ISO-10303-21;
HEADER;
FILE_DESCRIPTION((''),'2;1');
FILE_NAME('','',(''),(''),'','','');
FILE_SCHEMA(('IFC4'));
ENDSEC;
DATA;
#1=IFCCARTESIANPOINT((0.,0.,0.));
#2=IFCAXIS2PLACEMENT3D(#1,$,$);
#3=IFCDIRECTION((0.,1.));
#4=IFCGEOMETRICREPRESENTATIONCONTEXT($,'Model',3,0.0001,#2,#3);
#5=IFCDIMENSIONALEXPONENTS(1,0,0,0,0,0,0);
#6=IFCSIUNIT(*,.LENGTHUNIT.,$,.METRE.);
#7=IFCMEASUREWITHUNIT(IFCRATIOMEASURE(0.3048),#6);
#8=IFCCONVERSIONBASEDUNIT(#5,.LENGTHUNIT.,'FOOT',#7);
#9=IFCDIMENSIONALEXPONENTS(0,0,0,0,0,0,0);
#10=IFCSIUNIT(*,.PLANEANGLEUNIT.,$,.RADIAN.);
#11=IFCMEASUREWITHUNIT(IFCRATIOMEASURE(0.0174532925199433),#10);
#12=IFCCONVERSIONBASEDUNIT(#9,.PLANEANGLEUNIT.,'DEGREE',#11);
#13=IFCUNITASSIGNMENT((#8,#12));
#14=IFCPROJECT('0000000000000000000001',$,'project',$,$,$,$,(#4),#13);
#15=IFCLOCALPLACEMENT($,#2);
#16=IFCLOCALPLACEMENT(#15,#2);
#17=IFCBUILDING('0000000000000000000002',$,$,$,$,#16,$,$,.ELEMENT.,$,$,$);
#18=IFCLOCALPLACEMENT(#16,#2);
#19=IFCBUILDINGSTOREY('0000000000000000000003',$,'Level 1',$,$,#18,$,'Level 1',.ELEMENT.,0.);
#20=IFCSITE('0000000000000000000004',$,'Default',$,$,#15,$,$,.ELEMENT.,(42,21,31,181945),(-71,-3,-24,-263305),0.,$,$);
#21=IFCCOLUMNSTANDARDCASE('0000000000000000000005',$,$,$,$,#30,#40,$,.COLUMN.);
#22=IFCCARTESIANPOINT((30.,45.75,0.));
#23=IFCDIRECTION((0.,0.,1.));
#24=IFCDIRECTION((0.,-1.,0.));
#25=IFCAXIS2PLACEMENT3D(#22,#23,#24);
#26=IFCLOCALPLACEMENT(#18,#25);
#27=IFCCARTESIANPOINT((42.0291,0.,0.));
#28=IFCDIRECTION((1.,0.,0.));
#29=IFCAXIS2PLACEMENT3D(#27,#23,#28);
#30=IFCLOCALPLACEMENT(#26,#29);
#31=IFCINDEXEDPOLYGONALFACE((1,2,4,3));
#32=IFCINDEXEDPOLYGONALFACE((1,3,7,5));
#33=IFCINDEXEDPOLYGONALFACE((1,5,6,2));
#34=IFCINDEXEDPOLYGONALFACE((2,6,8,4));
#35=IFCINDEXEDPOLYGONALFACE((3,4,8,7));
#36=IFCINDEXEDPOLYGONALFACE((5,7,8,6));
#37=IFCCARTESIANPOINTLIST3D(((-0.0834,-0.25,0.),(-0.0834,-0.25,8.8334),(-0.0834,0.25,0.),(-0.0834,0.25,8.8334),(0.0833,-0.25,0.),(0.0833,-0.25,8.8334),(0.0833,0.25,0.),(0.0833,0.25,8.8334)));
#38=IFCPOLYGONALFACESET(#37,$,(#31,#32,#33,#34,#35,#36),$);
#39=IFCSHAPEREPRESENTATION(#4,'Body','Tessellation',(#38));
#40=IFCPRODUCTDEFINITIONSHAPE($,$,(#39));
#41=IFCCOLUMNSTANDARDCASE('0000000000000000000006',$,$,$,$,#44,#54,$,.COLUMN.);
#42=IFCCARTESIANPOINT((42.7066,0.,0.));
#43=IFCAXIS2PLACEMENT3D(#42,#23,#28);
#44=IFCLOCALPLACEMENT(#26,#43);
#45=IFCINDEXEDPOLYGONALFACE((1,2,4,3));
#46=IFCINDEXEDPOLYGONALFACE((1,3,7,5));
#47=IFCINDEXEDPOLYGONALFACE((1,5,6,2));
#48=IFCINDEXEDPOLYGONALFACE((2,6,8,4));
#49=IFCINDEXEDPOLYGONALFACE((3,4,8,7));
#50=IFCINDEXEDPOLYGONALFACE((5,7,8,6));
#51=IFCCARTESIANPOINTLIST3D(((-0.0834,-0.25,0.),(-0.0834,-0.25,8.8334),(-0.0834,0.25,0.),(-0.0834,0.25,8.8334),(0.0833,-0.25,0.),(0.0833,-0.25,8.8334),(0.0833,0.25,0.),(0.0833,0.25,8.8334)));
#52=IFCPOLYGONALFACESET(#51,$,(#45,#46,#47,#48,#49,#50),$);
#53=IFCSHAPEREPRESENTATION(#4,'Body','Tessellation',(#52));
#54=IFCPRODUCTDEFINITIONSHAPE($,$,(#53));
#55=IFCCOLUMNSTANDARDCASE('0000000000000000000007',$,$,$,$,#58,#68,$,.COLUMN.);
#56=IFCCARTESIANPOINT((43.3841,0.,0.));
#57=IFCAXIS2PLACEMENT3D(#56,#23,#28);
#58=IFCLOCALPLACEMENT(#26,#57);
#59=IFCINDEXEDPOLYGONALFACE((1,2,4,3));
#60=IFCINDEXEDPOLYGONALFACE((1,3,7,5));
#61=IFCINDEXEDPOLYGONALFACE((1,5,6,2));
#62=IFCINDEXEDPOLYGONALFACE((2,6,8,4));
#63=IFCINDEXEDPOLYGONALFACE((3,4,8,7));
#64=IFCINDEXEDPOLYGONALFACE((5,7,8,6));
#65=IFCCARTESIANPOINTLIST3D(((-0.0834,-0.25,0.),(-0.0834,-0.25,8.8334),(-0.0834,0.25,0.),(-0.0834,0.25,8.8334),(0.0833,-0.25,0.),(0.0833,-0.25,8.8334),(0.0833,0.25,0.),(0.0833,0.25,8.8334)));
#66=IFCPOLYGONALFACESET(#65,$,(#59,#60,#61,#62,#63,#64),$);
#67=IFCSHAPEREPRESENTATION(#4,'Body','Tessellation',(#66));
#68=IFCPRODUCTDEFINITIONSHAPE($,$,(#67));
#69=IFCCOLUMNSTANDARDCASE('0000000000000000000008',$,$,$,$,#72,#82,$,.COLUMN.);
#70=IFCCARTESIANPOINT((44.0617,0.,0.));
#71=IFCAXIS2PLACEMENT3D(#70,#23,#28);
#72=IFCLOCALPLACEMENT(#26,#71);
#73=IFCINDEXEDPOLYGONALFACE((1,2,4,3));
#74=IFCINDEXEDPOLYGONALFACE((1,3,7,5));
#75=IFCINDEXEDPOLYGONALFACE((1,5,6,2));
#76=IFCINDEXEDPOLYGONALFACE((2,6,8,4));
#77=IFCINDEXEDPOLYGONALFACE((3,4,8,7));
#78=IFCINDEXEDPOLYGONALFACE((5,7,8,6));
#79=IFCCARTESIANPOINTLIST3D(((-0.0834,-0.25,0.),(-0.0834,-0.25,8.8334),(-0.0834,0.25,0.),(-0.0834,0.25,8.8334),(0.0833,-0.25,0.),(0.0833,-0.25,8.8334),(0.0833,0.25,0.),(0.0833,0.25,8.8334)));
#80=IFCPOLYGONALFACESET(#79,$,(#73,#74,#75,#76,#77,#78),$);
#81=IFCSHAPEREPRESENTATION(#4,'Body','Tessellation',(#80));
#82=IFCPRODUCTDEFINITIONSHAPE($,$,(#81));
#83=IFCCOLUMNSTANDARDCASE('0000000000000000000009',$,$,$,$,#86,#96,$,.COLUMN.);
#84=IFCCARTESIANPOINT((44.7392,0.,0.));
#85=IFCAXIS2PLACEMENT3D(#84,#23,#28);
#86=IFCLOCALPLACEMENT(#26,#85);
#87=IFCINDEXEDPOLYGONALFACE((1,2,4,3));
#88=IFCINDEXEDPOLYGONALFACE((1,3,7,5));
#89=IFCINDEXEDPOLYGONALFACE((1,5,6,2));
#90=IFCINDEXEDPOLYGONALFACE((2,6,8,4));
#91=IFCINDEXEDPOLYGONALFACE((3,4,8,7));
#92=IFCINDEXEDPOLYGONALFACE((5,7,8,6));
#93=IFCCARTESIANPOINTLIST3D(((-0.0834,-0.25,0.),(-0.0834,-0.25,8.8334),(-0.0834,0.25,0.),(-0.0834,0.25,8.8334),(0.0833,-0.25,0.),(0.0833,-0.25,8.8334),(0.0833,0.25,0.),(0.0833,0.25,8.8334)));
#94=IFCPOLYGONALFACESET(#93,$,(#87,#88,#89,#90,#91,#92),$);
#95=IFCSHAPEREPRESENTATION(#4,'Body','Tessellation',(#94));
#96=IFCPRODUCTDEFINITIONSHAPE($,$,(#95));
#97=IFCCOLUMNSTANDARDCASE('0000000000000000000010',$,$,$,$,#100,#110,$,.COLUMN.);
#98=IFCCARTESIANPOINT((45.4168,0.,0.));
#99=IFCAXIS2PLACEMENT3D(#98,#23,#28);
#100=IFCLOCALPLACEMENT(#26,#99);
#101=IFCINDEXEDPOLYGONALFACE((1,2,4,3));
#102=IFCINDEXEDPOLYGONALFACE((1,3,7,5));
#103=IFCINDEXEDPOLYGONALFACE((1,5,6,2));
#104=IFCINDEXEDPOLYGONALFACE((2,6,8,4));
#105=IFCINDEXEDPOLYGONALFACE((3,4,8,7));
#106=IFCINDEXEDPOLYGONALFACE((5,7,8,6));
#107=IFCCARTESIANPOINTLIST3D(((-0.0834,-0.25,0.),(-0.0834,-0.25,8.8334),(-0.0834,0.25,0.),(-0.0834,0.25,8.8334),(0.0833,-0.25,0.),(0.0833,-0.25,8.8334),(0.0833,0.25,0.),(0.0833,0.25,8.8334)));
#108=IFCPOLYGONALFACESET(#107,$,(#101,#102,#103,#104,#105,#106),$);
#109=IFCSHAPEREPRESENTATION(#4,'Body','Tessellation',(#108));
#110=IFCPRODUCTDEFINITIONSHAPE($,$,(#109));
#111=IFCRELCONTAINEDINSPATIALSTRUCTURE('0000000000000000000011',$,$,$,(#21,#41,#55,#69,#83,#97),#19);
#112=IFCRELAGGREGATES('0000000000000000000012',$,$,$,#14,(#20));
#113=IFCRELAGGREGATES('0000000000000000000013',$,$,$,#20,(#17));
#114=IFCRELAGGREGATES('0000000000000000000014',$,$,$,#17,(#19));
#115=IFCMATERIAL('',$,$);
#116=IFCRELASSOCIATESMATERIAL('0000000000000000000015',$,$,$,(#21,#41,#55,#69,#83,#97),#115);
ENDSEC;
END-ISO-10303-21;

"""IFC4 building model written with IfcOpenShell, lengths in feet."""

from ifc_helpers import new_model, entity, si_unit, converted_unit, direction, frame, origin, place, context, project, spatial, rectangle, extrude, material, element, save


model = new_model("IFC4")

# Units and contexts
model_context = context("Model", 3, precision=0.0001, world=origin(), true_north=direction((0.0, 1.0)))
ifc_project = project(units=[converted_unit("LENGTHUNIT", "FOOT", entity("IfcRatioMeasure", 0.3048), si_unit("LENGTHUNIT", "METRE"), dimensions=[1, 0, 0, 0, 0, 0, 0]), converted_unit("PLANEANGLEUNIT", "DEGREE", entity("IfcRatioMeasure", 0.0174532925199433), si_unit("PLANEANGLEUNIT", "RADIAN"), dimensions=[0, 0, 0, 0, 0, 0, 0])], contexts=[model_context])

# Site, building, storey
site_placement = place(None, origin())
site = spatial("IfcSite", under=ifc_project, at=site_placement, Name="Default", CompositionType="ELEMENT", RefLatitude=(42, 21, 31, 181945), RefLongitude=(-71, -3, -24, -263305), RefElevation=0.0)
building_placement = place(site_placement, origin())
building = spatial("IfcBuilding", under=site, at=building_placement, CompositionType="ELEMENT")
storey_placement = place(building_placement, origin())
storey = spatial("IfcBuildingStorey", under=building, at=storey_placement, Name="Level 1", LongName="Level 1", CompositionType="ELEMENT", Elevation=0.0)

# Columns
ifc_material_1 = material(Name="")
placement_1 = place(storey_placement, frame((30.0, 45.75, 0.0), z_axis=(0.0, 0.0, 1.0), x_axis=(0.0, -1.0, 0.0)))
for number, where, z_axis, x_axis in (
    (1, (42.0291, 0.0, 0.0), (0.0, 0.0, 1.0), (1.0, 0.0, 0.0)),
    (2, (42.7066, 0.0, 0.0), (0.0, 0.0, 1.0), (1.0, 0.0, 0.0)),
    (3, (43.3841, 0.0, 0.0), (0.0, 0.0, 1.0), (1.0, 0.0, 0.0)),
    (4, (44.0617, 0.0, 0.0), (0.0, 0.0, 1.0), (1.0, 0.0, 0.0)),
    (5, (44.7392, 0.0, 0.0), (0.0, 0.0, 1.0), (1.0, 0.0, 0.0)),
    (6, (45.4168, 0.0, 0.0), (0.0, 0.0, 1.0), (1.0, 0.0, 0.0)),
):
    element("IfcColumnStandardCase", number, at=place(placement_1, frame(where, z_axis=z_axis, x_axis=x_axis)), inside=storey, material=ifc_material_1, PredefinedType="COLUMN", context=model_context, shape_type="SweptSolid", body=[
        extrude(rectangle(XDim=0.1667, YDim=0.5), origin(), (0.0, 0.0, 1.0), 8.8334),
    ])

save(model, "model.ifc")
